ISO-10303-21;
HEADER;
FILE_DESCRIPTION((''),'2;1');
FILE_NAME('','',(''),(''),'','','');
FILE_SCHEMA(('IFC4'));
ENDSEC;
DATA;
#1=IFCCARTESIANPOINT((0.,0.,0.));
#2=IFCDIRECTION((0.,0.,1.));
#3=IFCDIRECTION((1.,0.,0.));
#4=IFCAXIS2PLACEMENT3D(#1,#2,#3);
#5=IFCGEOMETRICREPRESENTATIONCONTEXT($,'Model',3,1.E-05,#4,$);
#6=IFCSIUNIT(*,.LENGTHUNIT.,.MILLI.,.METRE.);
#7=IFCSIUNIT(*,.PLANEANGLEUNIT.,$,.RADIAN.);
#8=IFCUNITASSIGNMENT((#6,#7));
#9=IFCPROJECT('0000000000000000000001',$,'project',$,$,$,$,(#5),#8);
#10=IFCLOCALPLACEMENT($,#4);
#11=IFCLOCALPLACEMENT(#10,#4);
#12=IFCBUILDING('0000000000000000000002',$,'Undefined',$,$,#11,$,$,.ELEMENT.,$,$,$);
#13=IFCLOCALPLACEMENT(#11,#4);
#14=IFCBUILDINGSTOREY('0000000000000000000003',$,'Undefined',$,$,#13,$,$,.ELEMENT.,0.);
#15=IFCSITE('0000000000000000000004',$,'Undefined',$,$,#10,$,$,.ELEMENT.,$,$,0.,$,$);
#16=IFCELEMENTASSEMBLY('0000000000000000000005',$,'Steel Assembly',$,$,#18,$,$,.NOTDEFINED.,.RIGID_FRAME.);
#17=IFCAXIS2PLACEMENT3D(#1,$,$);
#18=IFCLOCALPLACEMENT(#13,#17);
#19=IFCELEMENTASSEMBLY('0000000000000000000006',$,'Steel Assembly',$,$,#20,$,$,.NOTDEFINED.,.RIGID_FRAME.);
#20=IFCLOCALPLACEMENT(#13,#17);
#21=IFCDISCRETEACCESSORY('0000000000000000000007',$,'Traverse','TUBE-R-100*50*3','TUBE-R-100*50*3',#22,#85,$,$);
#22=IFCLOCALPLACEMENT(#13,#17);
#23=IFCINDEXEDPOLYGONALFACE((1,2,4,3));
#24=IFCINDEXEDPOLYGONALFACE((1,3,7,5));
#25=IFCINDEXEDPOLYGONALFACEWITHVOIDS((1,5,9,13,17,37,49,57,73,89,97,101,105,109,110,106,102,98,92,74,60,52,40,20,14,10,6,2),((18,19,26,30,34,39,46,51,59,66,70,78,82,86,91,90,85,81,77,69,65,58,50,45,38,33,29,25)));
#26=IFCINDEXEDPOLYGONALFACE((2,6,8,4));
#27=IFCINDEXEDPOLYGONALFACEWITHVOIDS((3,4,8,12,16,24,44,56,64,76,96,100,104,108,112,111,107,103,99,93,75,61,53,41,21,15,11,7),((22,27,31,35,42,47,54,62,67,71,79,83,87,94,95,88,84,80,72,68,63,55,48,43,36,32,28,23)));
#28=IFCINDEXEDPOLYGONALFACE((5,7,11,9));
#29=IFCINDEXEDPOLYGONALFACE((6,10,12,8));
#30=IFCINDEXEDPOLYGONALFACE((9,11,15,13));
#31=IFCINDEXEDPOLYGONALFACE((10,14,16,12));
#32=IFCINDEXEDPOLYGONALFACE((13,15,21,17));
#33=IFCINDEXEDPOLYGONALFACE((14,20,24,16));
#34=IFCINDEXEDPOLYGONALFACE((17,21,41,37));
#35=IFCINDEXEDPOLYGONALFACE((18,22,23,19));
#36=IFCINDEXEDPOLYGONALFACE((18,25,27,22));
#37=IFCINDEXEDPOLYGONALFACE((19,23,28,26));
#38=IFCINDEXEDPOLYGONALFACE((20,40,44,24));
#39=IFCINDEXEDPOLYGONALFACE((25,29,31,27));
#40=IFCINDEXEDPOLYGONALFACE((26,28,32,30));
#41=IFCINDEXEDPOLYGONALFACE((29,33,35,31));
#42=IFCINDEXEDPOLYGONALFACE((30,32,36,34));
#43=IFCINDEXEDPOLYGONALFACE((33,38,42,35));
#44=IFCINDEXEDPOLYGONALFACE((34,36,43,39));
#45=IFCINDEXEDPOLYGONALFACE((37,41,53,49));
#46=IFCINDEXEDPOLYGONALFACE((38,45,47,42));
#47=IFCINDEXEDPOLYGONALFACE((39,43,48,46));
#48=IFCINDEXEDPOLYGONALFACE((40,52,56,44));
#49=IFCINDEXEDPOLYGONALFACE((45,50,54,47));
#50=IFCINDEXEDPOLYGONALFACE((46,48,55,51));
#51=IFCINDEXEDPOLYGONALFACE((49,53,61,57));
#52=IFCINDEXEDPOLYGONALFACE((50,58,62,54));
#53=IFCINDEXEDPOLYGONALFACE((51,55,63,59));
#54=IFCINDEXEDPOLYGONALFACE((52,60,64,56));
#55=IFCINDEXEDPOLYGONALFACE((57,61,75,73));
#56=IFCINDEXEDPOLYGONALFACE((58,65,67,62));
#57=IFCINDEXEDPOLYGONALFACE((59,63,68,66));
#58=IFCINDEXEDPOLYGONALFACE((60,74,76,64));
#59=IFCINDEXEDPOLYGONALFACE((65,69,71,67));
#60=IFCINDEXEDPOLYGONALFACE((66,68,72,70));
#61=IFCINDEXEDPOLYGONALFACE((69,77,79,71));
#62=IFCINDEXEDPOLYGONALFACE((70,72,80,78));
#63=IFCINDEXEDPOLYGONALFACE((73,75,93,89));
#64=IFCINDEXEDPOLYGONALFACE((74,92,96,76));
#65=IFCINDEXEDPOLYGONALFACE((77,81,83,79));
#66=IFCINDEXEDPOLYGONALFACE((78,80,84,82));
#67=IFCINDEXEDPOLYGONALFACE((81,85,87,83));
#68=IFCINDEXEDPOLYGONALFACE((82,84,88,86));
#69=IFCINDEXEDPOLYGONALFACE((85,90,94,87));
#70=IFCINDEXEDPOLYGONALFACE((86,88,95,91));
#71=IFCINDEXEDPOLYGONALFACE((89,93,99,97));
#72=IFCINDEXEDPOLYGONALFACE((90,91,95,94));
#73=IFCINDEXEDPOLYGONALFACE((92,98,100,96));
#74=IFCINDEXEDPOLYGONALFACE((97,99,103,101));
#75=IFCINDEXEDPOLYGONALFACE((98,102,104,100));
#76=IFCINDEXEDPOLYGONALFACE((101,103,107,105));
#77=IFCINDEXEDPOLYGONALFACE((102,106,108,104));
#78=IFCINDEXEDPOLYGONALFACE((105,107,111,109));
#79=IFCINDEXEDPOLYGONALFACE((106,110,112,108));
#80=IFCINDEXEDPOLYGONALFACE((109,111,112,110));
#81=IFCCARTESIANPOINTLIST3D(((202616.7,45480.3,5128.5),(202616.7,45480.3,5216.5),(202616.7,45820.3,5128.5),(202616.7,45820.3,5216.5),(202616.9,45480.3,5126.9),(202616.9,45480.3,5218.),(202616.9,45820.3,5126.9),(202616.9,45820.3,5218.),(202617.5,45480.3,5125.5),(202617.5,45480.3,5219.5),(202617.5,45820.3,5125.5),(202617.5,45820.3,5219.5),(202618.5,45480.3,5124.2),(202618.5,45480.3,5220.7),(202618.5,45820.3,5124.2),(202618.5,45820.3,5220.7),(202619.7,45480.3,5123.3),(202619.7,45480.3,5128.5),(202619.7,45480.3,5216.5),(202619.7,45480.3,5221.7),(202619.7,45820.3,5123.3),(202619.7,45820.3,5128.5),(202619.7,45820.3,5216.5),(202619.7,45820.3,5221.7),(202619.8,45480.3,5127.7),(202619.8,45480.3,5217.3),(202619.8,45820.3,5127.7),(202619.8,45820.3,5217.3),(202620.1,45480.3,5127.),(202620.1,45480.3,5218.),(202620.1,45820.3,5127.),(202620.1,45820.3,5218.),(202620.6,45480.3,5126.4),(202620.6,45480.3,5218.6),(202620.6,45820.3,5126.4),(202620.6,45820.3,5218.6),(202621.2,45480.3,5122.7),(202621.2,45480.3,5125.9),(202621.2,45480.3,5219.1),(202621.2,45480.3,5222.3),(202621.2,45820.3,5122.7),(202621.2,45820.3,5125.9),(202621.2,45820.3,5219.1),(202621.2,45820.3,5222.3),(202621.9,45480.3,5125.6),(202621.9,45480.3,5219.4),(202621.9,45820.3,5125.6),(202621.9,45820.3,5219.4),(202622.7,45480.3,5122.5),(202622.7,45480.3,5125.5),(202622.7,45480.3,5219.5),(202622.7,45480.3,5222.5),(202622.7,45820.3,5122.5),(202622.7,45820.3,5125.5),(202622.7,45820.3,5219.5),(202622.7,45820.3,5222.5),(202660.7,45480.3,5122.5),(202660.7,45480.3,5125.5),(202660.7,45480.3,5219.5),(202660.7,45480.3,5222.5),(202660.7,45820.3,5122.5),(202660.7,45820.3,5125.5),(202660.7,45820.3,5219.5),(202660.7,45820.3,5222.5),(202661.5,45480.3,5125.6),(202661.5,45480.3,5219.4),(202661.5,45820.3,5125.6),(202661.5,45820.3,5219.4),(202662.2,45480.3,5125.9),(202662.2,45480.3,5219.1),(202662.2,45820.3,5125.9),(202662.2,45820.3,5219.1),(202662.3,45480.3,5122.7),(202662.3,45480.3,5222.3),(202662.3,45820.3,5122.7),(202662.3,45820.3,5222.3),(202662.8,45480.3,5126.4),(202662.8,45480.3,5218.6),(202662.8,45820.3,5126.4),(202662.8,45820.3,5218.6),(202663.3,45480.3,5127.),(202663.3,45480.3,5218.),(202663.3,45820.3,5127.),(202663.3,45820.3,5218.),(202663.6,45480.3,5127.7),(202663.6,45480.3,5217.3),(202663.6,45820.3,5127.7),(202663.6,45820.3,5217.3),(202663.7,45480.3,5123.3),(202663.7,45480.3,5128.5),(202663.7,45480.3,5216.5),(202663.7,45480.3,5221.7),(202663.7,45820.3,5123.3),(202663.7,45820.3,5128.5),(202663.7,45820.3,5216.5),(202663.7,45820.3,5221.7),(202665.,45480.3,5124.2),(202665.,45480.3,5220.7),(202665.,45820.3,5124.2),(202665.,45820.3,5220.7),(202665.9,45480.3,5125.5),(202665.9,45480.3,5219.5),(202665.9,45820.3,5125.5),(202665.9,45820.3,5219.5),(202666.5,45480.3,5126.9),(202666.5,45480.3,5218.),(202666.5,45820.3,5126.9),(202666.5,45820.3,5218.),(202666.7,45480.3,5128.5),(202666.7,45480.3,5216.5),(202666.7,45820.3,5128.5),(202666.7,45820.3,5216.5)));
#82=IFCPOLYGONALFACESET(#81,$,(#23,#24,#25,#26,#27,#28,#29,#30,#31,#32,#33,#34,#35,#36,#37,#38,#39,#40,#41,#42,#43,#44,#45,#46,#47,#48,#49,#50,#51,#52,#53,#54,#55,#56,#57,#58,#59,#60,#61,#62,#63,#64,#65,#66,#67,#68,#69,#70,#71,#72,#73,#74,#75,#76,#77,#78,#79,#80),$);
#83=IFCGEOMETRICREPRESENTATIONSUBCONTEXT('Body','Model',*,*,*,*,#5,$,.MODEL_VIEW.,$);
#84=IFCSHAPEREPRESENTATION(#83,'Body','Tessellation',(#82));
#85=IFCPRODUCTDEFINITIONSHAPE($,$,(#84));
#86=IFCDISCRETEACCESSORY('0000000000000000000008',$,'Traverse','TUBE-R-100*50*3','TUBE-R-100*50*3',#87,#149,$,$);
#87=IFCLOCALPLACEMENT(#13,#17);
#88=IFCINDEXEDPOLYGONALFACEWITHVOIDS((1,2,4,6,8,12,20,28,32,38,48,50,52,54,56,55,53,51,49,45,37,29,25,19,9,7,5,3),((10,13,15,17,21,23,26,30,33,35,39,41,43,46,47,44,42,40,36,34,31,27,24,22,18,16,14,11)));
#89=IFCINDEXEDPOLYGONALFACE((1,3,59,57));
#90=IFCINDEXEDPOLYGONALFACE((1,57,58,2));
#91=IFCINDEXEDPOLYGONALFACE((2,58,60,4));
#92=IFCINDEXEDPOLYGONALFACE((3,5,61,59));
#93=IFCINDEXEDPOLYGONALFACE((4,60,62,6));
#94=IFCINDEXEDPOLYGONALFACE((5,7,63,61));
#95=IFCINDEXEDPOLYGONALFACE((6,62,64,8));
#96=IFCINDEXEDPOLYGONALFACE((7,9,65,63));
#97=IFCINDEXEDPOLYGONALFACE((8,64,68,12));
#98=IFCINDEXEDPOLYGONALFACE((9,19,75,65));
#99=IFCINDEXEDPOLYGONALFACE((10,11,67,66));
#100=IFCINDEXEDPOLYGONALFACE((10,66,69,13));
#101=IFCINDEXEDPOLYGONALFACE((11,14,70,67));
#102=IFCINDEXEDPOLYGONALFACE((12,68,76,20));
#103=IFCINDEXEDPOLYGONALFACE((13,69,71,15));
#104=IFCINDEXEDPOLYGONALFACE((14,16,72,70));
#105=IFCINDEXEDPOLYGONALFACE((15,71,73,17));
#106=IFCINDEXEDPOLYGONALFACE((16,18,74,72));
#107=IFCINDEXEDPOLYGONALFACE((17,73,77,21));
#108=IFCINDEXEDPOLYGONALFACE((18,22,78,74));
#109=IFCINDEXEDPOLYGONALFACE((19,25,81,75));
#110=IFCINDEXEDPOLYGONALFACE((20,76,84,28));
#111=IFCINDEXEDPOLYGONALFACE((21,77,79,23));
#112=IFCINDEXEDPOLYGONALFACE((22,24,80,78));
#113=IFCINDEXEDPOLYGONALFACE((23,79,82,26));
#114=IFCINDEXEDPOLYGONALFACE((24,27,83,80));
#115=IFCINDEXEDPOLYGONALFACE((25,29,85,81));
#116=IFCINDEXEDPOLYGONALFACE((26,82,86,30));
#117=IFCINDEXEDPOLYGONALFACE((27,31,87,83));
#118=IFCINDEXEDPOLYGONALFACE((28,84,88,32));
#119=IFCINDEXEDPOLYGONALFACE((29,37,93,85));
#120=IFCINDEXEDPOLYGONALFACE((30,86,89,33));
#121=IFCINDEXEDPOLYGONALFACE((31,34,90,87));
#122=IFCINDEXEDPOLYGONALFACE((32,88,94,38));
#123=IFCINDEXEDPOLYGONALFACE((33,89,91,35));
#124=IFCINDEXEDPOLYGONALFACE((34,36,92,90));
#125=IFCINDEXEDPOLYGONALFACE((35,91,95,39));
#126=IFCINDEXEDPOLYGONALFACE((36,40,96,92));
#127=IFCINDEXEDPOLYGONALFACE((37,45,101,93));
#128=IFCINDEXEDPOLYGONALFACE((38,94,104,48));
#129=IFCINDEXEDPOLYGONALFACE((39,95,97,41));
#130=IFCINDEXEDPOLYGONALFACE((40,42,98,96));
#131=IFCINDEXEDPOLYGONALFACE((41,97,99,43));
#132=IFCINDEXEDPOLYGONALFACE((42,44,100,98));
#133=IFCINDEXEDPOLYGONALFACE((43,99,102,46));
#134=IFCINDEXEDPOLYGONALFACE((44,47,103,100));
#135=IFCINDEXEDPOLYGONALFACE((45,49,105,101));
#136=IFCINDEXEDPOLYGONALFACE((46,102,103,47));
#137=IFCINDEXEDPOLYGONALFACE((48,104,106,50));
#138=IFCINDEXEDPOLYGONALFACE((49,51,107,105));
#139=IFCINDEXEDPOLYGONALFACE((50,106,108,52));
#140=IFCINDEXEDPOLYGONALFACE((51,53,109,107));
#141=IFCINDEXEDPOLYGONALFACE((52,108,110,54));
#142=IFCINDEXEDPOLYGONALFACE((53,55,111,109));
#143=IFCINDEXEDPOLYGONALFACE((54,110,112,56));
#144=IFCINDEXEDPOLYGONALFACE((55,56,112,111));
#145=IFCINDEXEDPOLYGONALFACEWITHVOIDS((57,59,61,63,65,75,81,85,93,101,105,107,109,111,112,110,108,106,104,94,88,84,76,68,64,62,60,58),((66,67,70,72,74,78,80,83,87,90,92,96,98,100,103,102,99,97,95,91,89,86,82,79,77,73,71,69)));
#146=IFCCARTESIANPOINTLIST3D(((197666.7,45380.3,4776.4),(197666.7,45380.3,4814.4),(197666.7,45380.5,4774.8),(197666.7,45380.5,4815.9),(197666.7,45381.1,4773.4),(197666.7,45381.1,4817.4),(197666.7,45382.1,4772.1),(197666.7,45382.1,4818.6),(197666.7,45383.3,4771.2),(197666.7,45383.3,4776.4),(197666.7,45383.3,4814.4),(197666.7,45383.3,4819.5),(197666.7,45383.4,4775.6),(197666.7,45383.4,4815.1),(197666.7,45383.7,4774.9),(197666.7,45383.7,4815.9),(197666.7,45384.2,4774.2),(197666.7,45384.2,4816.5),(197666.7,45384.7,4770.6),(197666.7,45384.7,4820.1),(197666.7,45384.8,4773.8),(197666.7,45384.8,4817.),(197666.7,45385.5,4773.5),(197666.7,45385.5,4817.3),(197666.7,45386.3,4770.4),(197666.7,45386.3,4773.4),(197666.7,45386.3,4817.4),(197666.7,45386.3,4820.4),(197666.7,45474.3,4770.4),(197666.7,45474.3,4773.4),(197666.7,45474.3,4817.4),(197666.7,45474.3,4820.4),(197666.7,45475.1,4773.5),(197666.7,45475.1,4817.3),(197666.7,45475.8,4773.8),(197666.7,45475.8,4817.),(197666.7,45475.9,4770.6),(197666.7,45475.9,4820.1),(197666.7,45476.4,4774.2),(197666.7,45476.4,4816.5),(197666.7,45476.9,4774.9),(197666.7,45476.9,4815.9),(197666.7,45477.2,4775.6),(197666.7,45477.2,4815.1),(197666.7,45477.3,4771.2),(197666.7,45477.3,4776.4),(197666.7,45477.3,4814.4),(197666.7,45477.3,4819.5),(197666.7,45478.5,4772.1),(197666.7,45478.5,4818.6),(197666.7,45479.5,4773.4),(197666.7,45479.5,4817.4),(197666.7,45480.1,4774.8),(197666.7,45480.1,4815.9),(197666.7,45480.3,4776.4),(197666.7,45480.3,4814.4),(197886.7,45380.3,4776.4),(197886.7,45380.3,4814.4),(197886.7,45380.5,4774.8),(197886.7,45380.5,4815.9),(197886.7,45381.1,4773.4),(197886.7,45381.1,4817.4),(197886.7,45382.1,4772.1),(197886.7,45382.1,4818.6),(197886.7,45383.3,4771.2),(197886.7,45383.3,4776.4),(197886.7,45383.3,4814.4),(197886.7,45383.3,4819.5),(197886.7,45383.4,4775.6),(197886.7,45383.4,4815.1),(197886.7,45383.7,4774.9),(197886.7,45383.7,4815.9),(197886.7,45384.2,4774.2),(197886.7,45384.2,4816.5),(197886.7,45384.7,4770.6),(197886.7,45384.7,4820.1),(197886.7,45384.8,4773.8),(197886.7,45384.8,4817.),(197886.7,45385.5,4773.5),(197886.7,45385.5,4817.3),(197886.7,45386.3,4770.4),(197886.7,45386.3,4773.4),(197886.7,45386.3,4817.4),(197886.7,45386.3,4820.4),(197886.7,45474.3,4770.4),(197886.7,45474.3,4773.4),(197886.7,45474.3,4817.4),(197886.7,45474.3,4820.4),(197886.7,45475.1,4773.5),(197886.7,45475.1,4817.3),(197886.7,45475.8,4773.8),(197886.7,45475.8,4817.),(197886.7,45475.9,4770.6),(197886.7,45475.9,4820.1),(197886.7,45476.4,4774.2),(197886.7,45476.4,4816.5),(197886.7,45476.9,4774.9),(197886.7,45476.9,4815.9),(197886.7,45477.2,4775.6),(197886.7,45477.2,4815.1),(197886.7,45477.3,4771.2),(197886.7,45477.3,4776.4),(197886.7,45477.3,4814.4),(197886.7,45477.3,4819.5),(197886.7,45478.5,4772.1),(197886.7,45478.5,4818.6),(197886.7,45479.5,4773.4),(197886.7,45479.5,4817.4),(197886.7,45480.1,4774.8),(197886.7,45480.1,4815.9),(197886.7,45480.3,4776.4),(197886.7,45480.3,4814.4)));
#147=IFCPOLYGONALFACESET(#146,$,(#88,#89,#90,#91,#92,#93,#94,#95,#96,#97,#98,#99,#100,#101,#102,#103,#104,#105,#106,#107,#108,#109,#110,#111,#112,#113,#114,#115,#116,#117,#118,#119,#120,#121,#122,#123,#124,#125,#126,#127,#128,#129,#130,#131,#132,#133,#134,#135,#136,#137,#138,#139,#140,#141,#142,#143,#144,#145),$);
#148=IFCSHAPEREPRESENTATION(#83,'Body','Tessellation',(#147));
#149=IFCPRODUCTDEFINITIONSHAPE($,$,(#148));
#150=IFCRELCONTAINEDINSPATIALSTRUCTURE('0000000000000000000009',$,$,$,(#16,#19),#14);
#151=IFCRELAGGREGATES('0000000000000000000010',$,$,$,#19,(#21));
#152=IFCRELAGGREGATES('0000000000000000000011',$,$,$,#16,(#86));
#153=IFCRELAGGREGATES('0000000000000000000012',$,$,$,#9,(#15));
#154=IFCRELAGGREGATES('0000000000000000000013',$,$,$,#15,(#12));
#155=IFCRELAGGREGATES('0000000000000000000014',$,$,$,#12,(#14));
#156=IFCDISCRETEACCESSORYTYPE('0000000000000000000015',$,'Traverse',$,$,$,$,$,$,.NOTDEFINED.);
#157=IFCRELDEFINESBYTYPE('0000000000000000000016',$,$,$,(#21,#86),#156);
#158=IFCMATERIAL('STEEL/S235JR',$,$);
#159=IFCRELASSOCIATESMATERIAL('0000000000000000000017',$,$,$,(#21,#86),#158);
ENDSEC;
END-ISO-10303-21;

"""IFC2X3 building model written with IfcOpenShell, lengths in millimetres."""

from ifc_helpers import new_model, si_unit, frame, origin_with_axes, origin_2d_with_axis, place, context, subcontext, project, spatial, hollow_rectangle, extrude, material, type_object, element, aggregate, save


model = new_model("IFC2X3")

# Units and contexts
model_context = context("Model", 3, precision=1e-05, world=origin_with_axes())
body_context = subcontext(model_context, "Body", "Model", "MODEL_VIEW")
ifc_project = project(units=[si_unit("LENGTHUNIT", "METRE", prefix="MILLI"), si_unit("PLANEANGLEUNIT", "RADIAN")], contexts=[model_context])

# Site, building, storey
site_placement = place(None, origin_with_axes())
site = spatial("IfcSite", under=ifc_project, at=site_placement, Name="Undefined", CompositionType="ELEMENT", RefElevation=0.0)
building_placement = place(site_placement, origin_with_axes())
building = spatial("IfcBuilding", under=site, at=building_placement, Name="Undefined", CompositionType="ELEMENT")
storey_placement = place(building_placement, origin_with_axes())
storey = spatial("IfcBuildingStorey", under=building, at=storey_placement, Name="Undefined", CompositionType="ELEMENT", Elevation=0.0)

# Shared definitions
ifc_material_1 = material(Name="STEEL/S235JR")

# Element assembly
assembly_1_placement = place(storey_placement, origin_with_axes())
assembly_1 = element("IfcElementAssembly", 1, at=assembly_1_placement, inside=storey, Name="Steel Assembly", AssemblyPlace="NOTDEFINED", PredefinedType="RIGID_FRAME")

# Element assembly
assembly_2_placement = place(storey_placement, origin_with_axes())
assembly_2 = element("IfcElementAssembly", 2, at=assembly_2_placement, inside=storey, Name="Steel Assembly", AssemblyPlace="NOTDEFINED", PredefinedType="RIGID_FRAME")

# Discrete accessories
discrete_accessory_type_1 = type_object("IfcDiscreteAccessoryType", Name="Traverse")
discrete_accessory_1_placement = place(assembly_2_placement, frame((202641.7, 45480.3, 5172.5), z_axis=(0.0, 0.0, 1.0), x_axis=(0.0, 1.0, 0.0)))
discrete_accessory_1 = element("IfcDiscreteAccessory", 3, at=discrete_accessory_1_placement, type_object=discrete_accessory_type_1, material=ifc_material_1, Name="Traverse", Description="TUBE-R-100*50*3", ObjectType="TUBE-R-100*50*3", context=body_context, shape_type="SweptSolid", body=[
    extrude(hollow_rectangle(XDim=50.0, YDim=100.0, WallThickness=3.0, InnerFilletRadius=3.0, OuterFilletRadius=6.0, at=origin_2d_with_axis()), frame((340.0, 0.0, 0.0), z_axis=(-1.0, 0.0, 0.0), x_axis=(0.0, -1.0, 0.0)), (0.0, 0.0, 1.0), 340.0),
])
discrete_accessory_2_placement = place(assembly_1_placement, frame((197886.7, 45430.3, 4795.4), z_axis=(0.0, 1.0, 0.0), x_axis=(-1.0, 0.0, 0.0)))
discrete_accessory_2 = element("IfcDiscreteAccessory", 4, at=discrete_accessory_2_placement, type_object=discrete_accessory_type_1, material=ifc_material_1, Name="Traverse", Description="TUBE-R-100*50*3", ObjectType="TUBE-R-100*50*3", context=body_context, shape_type="SweptSolid", body=[
    extrude(hollow_rectangle(XDim=50.0, YDim=100.0, WallThickness=3.0, InnerFilletRadius=3.0, OuterFilletRadius=6.0, at=origin_2d_with_axis()), frame((220.0, 0.0, 0.0), z_axis=(-1.0, 0.0, 0.0), x_axis=(0.0, -1.0, 0.0)), (0.0, 0.0, 1.0), 220.0),
])

aggregate(assembly_2, [discrete_accessory_1])
aggregate(assembly_1, [discrete_accessory_2])

save(model, "model.ifc")
